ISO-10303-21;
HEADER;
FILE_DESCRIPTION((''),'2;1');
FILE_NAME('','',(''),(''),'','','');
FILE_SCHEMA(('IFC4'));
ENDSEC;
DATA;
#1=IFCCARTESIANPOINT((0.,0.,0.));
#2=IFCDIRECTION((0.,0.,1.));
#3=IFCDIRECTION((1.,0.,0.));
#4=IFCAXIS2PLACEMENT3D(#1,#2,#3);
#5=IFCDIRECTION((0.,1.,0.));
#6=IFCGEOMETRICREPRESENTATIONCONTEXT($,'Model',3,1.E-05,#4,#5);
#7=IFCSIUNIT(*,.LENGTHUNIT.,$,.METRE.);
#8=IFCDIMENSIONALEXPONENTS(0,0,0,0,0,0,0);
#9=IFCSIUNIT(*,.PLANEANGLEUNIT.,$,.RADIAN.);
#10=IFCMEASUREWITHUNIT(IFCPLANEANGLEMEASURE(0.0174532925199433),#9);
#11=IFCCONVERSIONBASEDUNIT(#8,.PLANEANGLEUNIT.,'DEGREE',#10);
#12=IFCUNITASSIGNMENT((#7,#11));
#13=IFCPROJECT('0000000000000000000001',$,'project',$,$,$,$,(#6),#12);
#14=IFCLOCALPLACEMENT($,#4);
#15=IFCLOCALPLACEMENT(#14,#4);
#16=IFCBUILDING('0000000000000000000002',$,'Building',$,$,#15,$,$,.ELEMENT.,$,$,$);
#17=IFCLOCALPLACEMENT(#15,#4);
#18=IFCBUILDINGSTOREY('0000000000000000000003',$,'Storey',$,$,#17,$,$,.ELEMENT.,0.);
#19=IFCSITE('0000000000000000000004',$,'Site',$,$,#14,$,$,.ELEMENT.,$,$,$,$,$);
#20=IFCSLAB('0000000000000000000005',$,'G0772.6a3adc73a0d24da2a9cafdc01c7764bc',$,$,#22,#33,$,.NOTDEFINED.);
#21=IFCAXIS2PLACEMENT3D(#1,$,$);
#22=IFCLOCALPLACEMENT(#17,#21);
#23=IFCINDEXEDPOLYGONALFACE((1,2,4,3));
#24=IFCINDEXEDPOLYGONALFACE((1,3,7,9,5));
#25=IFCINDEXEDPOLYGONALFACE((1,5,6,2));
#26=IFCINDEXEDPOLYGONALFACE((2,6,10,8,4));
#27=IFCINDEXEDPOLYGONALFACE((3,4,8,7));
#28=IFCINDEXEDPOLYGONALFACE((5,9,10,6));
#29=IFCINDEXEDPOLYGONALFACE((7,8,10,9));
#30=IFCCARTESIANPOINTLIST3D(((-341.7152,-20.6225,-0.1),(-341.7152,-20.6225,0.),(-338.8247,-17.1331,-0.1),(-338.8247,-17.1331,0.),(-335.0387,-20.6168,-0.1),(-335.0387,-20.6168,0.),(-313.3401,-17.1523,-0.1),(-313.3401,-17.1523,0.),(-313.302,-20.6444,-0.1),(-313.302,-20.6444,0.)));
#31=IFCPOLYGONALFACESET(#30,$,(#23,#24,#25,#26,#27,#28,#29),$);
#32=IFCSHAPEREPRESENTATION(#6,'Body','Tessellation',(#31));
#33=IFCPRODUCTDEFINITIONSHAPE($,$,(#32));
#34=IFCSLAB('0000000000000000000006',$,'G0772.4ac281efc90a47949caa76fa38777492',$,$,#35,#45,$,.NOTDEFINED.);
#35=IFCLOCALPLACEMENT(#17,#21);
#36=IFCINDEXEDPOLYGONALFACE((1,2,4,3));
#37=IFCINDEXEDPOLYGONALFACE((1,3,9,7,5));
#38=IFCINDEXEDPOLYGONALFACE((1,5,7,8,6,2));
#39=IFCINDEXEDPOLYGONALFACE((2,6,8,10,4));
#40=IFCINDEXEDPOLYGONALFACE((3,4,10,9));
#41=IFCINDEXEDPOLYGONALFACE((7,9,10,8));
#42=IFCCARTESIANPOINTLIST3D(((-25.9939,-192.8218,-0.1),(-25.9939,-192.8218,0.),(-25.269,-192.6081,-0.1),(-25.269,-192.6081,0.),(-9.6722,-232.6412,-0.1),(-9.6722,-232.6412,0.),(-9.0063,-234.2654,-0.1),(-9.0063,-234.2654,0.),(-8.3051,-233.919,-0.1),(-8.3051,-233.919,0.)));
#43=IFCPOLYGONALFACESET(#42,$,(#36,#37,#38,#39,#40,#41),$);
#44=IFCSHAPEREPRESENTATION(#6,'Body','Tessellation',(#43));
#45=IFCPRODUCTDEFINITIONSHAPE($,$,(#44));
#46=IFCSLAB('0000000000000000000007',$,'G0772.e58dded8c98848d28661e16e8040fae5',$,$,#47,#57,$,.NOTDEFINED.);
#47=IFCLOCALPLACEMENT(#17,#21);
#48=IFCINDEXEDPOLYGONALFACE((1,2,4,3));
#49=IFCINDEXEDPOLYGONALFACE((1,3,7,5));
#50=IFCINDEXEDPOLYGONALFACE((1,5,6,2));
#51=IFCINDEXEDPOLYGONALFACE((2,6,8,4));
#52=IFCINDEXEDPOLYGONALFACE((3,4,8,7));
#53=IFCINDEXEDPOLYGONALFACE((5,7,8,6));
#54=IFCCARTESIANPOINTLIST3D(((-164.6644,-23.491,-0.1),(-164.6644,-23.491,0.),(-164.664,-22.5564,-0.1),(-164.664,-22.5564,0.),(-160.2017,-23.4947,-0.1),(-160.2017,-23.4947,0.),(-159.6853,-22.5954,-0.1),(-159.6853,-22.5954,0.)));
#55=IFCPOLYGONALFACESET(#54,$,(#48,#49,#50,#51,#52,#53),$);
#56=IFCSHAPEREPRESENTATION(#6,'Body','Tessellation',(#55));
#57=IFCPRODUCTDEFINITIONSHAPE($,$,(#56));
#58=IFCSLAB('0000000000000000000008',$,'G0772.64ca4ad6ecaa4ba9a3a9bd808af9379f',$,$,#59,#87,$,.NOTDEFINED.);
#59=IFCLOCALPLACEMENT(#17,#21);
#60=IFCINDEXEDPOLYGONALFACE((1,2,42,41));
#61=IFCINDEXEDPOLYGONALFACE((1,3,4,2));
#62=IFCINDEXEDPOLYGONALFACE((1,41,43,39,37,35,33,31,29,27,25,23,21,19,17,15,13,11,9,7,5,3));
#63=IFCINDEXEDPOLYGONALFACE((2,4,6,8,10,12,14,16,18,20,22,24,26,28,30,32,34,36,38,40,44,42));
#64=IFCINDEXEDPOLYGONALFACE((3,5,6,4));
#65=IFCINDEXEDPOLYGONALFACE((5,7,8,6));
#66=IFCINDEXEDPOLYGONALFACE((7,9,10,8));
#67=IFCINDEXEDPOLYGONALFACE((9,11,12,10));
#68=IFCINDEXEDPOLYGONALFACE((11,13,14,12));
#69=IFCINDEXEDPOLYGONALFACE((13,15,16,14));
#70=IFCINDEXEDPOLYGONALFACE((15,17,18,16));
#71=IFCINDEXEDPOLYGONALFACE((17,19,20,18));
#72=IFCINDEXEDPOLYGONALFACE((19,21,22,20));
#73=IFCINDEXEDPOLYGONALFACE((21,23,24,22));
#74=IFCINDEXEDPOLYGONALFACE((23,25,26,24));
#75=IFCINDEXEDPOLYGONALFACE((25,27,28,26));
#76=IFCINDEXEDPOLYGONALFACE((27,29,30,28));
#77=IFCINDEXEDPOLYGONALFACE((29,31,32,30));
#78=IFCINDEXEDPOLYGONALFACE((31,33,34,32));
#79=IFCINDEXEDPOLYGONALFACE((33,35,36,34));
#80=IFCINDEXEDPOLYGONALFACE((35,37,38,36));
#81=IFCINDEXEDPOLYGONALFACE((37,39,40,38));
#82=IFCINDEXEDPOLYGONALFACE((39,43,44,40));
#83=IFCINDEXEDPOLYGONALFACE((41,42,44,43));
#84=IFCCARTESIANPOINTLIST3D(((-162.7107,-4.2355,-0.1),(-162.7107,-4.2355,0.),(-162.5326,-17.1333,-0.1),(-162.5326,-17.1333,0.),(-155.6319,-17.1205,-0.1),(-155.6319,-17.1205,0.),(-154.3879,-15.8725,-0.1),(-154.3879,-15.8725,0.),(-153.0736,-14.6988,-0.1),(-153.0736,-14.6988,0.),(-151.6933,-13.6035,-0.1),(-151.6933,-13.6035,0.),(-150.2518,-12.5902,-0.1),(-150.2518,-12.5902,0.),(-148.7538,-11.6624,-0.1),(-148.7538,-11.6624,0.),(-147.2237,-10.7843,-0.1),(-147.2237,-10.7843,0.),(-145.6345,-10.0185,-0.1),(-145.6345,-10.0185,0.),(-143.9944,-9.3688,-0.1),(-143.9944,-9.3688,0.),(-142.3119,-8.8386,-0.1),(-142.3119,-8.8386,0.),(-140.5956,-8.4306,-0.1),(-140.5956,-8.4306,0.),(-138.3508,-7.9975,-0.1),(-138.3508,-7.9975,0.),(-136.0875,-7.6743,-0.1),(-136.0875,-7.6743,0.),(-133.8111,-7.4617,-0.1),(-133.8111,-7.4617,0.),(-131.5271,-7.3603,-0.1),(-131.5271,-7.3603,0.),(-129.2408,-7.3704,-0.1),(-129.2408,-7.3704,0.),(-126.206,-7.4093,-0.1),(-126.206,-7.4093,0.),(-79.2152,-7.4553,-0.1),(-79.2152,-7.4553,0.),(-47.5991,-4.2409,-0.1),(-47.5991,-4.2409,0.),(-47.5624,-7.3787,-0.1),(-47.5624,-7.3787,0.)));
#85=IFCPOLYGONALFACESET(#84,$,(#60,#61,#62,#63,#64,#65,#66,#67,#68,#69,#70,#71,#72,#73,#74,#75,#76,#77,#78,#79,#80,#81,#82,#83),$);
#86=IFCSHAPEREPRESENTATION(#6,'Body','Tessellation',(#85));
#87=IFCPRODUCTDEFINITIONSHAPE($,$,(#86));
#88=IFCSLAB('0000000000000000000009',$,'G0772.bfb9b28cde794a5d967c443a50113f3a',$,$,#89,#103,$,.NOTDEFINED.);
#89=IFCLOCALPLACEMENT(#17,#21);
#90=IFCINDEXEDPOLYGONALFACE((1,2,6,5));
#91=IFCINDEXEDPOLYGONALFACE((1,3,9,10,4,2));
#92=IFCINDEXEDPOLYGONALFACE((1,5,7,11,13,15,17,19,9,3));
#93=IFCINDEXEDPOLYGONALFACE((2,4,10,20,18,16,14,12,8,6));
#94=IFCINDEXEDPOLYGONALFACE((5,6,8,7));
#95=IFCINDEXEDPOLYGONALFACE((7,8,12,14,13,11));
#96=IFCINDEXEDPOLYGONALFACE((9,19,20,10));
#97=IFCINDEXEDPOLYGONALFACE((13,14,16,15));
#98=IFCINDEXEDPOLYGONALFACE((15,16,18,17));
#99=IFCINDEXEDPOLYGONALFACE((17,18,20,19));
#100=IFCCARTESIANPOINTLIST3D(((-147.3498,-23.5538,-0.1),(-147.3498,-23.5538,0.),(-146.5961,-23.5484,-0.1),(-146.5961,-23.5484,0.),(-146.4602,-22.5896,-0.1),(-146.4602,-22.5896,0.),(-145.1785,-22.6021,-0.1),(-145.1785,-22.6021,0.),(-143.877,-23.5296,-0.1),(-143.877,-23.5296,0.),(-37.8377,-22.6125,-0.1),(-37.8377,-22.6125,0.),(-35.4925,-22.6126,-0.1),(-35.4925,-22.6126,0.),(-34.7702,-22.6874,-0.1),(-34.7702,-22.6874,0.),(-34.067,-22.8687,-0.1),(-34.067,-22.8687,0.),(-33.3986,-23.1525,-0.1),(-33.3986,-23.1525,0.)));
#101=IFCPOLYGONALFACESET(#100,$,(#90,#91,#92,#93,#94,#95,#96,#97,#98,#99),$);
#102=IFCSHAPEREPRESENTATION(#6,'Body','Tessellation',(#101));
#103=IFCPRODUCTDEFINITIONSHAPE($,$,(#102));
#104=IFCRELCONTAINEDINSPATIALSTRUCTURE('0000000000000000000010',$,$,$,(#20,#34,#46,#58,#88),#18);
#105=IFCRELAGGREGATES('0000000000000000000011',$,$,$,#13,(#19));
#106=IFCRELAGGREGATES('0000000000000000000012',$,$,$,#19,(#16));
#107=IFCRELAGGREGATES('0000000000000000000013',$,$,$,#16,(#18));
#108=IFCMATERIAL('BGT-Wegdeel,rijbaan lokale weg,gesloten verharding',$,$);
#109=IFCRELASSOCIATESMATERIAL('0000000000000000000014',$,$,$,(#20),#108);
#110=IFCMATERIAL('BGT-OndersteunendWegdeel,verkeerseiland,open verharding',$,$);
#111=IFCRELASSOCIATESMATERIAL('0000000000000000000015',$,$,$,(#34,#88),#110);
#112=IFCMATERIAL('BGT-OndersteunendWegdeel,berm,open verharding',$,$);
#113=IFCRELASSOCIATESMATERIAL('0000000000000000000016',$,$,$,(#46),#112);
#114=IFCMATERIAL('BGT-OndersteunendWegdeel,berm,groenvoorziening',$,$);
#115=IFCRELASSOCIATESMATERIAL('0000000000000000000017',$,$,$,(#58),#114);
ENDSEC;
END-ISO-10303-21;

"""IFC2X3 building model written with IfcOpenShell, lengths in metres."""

from ifc_helpers import new_model, entity, si_unit, converted_unit, direction, frame, origin_with_axes, place, context, project, spatial, polyline, outline, extrude, material, element, save


model = new_model("IFC2X3")

# Units and contexts
model_context = context("Model", 3, precision=1e-05, world=origin_with_axes(), true_north=direction((0.0, 1.0, 0.0)))
ifc_project = project(units=[si_unit("LENGTHUNIT", "METRE"), converted_unit("PLANEANGLEUNIT", "DEGREE", entity("IfcPlaneAngleMeasure", 0.0174532925199433), si_unit("PLANEANGLEUNIT", "RADIAN"), dimensions=[0, 0, 0, 0, 0, 0, 0])], contexts=[model_context])

# Site, building, storey
site_placement = place(None, origin_with_axes())
site = spatial("IfcSite", under=ifc_project, at=site_placement, Name="Site", CompositionType="ELEMENT")
building_placement = place(site_placement, origin_with_axes())
building = spatial("IfcBuilding", under=site, at=building_placement, Name="Building", CompositionType="ELEMENT")
storey_placement = place(building_placement, origin_with_axes())
storey = spatial("IfcBuildingStorey", under=building, at=storey_placement, Name="Storey", CompositionType="ELEMENT", Elevation=0.0)

# Slabs
ifc_material_1 = material(Name="BGT-Wegdeel,rijbaan lokale weg,gesloten verharding")
slab_1_placement = place(storey_placement, frame((0.0, 0.0, -0.1), z_axis=(0.0, 0.0, 1.0), x_axis=(1.0, 0.0, 0.0)))
element("IfcSlab", 1, at=slab_1_placement, inside=storey, material=ifc_material_1, Name="G0772.6a3adc73a0d24da2a9cafdc01c7764bc", PredefinedType="NOTDEFINED", context=model_context, shape_type="SweptSolid", body=[
    extrude(outline(polyline([(-313.3401, -17.1523), (-313.302, -20.6444), (-335.0387, -20.6168), (-341.7152, -20.6225), (-338.8247, -17.1331), (-313.3401, -17.1523)])), origin_with_axes(), (0.0, 0.0, 1.0), 0.1),
])
ifc_material_2 = material(Name="BGT-OndersteunendWegdeel,verkeerseiland,open verharding")
slab_2_placement = place(storey_placement, frame((0.0, 0.0, -0.1), z_axis=(0.0, 0.0, 1.0), x_axis=(1.0, 0.0, 0.0)))
element("IfcSlab", 2, at=slab_2_placement, inside=storey, material=ifc_material_2, Name="G0772.4ac281efc90a47949caa76fa38777492", PredefinedType="NOTDEFINED", context=model_context, shape_type="SweptSolid", body=[
    extrude(outline(polyline([(-9.0063, -234.2654), (-9.6722, -232.6412), (-25.9939, -192.8218), (-25.269, -192.6081), (-8.3051, -233.919), (-9.0063, -234.2654)])), origin_with_axes(), (0.0, 0.0, 1.0), 0.1),
])
ifc_material_3 = material(Name="BGT-OndersteunendWegdeel,berm,open verharding")
slab_3_placement = place(storey_placement, frame((0.0, 0.0, -0.1), z_axis=(0.0, 0.0, 1.0), x_axis=(1.0, 0.0, 0.0)))
element("IfcSlab", 3, at=slab_3_placement, inside=storey, material=ifc_material_3, Name="G0772.e58dded8c98848d28661e16e8040fae5", PredefinedType="NOTDEFINED", context=model_context, shape_type="SweptSolid", body=[
    extrude(outline(polyline([(-159.6853, -22.5954), (-160.2017, -23.4947), (-164.6644, -23.491), (-164.664, -22.5564), (-159.6853, -22.5954)])), origin_with_axes(), (0.0, 0.0, 1.0), 0.1),
])
ifc_material_4 = material(Name="BGT-OndersteunendWegdeel,berm,groenvoorziening")
slab_4_placement = place(storey_placement, frame((0.0, 0.0, -0.1), z_axis=(0.0, 0.0, 1.0), x_axis=(1.0, 0.0, 0.0)))
element("IfcSlab", 4, at=slab_4_placement, inside=storey, material=ifc_material_4, Name="G0772.64ca4ad6ecaa4ba9a3a9bd808af9379f", PredefinedType="NOTDEFINED", context=model_context, shape_type="SweptSolid", body=[
    extrude(outline(polyline([(-47.5991, -4.2409), (-47.5624, -7.3787), (-79.2152, -7.4553), (-126.206, -7.4093), (-129.2408, -7.3704), (-131.5271, -7.3603), (-133.8111, -7.4617), (-136.0875, -7.6743), (-138.3508, -7.9975), (-140.5956, -8.4306), (-142.3119, -8.8386), (-143.9944, -9.3688), (-145.6345, -10.0185), (-147.2237, -10.7843), (-148.7538, -11.6624), (-150.2518, -12.5902), (-151.6933, -13.6035), (-153.0736, -14.6988), (-154.3879, -15.8725), (-155.6319, -17.1205), (-162.5326, -17.1333), (-162.7107, -4.2355), (-47.5991, -4.2409)])), origin_with_axes(), (0.0, 0.0, 1.0), 0.1),
])
slab_5_placement = place(storey_placement, frame((0.0, 0.0, -0.1), z_axis=(0.0, 0.0, 1.0), x_axis=(1.0, 0.0, 0.0)))
element("IfcSlab", 5, at=slab_5_placement, inside=storey, material=ifc_material_2, Name="G0772.bfb9b28cde794a5d967c443a50113f3a", PredefinedType="NOTDEFINED", context=model_context, shape_type="SweptSolid", body=[
    extrude(outline(polyline([(-37.8377, -22.6125), (-35.4925, -22.6126), (-34.7702, -22.6874), (-34.067, -22.8687), (-33.3986, -23.1525), (-143.877, -23.5296), (-146.5961, -23.5484), (-147.3498, -23.5538), (-146.4602, -22.5896), (-145.1785, -22.6021), (-37.8377, -22.6125)])), origin_with_axes(), (0.0, 0.0, 1.0), 0.1),
])

save(model, "model.ifc")
